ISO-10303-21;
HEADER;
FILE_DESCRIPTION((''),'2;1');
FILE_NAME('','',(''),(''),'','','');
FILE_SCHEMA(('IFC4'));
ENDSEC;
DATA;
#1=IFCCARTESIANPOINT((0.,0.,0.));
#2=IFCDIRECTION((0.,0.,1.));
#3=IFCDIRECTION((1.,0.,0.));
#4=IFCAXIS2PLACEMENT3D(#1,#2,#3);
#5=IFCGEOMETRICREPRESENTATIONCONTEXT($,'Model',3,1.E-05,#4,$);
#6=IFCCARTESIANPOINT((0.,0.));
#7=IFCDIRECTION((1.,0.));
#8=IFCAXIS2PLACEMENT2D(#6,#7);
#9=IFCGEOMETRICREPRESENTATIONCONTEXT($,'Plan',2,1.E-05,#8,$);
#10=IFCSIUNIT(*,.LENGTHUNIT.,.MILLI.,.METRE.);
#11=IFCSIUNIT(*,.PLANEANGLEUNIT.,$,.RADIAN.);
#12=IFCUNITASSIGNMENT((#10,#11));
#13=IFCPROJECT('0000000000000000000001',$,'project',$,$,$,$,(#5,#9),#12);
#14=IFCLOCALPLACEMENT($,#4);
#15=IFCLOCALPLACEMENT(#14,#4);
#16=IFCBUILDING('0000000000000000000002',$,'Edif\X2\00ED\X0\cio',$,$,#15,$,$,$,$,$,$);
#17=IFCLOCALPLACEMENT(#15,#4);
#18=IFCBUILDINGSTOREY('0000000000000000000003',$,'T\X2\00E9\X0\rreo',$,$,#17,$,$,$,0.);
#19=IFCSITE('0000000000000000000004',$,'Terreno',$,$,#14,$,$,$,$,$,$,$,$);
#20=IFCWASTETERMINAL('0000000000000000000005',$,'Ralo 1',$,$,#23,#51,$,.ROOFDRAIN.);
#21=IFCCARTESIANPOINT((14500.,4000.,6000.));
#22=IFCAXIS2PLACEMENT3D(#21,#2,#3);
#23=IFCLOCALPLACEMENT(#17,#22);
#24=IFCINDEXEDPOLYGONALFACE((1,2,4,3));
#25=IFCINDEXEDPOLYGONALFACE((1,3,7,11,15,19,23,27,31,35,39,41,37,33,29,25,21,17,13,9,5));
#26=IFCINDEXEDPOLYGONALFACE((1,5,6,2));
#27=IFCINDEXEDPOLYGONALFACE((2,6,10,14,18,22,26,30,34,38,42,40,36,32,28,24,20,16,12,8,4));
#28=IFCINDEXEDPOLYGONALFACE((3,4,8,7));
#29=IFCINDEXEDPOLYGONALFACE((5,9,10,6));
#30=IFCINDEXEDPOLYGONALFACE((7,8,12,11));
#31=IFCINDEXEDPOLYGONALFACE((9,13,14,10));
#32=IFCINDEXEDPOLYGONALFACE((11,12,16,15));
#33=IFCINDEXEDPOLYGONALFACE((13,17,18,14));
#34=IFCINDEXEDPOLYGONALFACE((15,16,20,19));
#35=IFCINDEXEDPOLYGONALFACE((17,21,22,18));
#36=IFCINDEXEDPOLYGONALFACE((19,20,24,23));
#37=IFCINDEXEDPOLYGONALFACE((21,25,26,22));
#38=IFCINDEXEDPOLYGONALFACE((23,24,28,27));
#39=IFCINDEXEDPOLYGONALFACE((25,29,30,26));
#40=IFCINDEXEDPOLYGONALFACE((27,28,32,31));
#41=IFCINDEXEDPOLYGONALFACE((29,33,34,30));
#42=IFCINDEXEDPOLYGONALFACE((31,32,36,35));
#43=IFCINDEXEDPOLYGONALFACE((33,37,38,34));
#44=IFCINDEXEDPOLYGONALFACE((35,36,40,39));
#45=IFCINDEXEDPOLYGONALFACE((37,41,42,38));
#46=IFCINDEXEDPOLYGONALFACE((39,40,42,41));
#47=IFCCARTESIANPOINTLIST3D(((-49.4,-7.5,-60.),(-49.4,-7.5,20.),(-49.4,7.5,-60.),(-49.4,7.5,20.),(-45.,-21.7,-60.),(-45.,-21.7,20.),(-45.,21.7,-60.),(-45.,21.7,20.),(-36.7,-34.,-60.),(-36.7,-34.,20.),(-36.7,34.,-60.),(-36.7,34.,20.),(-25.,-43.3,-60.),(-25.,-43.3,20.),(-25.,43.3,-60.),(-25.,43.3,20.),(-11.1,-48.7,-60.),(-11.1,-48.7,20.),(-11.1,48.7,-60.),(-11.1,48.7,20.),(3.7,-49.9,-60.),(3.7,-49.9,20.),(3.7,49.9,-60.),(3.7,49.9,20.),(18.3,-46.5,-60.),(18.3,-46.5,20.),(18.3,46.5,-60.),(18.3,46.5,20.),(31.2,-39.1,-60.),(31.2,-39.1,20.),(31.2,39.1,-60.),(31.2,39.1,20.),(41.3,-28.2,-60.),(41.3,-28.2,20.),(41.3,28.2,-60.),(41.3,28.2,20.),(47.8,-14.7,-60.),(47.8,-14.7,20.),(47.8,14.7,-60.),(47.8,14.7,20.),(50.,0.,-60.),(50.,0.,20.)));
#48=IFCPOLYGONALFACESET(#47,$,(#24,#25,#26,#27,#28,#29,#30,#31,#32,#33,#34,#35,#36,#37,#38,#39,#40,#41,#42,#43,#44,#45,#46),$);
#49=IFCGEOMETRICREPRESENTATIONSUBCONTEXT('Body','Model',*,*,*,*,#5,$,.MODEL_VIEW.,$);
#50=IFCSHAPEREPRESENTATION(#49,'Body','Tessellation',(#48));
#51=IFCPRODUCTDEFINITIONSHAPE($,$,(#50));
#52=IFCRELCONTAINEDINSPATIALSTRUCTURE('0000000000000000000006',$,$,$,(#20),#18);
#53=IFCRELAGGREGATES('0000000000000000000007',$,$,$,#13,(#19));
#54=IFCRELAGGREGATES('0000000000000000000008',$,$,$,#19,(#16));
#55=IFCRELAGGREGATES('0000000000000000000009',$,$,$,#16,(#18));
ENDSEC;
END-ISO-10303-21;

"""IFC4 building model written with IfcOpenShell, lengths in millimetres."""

from ifc_helpers import new_model, si_unit, frame, origin_with_axes, origin_2d, origin_2d_with_axis, place, context, subcontext, project, spatial, circle, extrude, element, save


model = new_model("IFC4")

# Units and contexts
model_context = context("Model", 3, precision=1e-05, world=origin_with_axes())
plan_context = context("Plan", 2, precision=1e-05, world=origin_2d_with_axis())
body_context = subcontext(model_context, "Body", "Model", "MODEL_VIEW")
ifc_project = project(units=[si_unit("LENGTHUNIT", "METRE", prefix="MILLI"), si_unit("PLANEANGLEUNIT", "RADIAN")], contexts=[model_context, plan_context])

# Site, building, storey
site_placement = place(None, origin_with_axes())
site = spatial("IfcSite", under=ifc_project, at=site_placement, Name="Terreno")
building_placement = place(site_placement, origin_with_axes())
building = spatial("IfcBuilding", under=site, at=building_placement, Name="Edifício")
storey_placement = place(building_placement, origin_with_axes())
storey = spatial("IfcBuildingStorey", under=building, at=storey_placement, Name="Térreo", Elevation=0.0)

# Waste terminal
waste_terminal_placement = place(storey_placement, frame((14500.0, 4000.0, 6000.0), z_axis=(0.0, 0.0, 1.0), x_axis=(1.0, 0.0, 0.0)))
element("IfcWasteTerminal", 1, at=waste_terminal_placement, inside=storey, Name="Ralo 1", PredefinedType="ROOFDRAIN", context=body_context, shape_type="SweptSolid", body=[
    extrude(circle(Radius=50.0, at=origin_2d()), frame((0.0, 0.0, -60.0)), (0.0, 0.0, 1.0), 80.0),
])

save(model, "model.ifc")
